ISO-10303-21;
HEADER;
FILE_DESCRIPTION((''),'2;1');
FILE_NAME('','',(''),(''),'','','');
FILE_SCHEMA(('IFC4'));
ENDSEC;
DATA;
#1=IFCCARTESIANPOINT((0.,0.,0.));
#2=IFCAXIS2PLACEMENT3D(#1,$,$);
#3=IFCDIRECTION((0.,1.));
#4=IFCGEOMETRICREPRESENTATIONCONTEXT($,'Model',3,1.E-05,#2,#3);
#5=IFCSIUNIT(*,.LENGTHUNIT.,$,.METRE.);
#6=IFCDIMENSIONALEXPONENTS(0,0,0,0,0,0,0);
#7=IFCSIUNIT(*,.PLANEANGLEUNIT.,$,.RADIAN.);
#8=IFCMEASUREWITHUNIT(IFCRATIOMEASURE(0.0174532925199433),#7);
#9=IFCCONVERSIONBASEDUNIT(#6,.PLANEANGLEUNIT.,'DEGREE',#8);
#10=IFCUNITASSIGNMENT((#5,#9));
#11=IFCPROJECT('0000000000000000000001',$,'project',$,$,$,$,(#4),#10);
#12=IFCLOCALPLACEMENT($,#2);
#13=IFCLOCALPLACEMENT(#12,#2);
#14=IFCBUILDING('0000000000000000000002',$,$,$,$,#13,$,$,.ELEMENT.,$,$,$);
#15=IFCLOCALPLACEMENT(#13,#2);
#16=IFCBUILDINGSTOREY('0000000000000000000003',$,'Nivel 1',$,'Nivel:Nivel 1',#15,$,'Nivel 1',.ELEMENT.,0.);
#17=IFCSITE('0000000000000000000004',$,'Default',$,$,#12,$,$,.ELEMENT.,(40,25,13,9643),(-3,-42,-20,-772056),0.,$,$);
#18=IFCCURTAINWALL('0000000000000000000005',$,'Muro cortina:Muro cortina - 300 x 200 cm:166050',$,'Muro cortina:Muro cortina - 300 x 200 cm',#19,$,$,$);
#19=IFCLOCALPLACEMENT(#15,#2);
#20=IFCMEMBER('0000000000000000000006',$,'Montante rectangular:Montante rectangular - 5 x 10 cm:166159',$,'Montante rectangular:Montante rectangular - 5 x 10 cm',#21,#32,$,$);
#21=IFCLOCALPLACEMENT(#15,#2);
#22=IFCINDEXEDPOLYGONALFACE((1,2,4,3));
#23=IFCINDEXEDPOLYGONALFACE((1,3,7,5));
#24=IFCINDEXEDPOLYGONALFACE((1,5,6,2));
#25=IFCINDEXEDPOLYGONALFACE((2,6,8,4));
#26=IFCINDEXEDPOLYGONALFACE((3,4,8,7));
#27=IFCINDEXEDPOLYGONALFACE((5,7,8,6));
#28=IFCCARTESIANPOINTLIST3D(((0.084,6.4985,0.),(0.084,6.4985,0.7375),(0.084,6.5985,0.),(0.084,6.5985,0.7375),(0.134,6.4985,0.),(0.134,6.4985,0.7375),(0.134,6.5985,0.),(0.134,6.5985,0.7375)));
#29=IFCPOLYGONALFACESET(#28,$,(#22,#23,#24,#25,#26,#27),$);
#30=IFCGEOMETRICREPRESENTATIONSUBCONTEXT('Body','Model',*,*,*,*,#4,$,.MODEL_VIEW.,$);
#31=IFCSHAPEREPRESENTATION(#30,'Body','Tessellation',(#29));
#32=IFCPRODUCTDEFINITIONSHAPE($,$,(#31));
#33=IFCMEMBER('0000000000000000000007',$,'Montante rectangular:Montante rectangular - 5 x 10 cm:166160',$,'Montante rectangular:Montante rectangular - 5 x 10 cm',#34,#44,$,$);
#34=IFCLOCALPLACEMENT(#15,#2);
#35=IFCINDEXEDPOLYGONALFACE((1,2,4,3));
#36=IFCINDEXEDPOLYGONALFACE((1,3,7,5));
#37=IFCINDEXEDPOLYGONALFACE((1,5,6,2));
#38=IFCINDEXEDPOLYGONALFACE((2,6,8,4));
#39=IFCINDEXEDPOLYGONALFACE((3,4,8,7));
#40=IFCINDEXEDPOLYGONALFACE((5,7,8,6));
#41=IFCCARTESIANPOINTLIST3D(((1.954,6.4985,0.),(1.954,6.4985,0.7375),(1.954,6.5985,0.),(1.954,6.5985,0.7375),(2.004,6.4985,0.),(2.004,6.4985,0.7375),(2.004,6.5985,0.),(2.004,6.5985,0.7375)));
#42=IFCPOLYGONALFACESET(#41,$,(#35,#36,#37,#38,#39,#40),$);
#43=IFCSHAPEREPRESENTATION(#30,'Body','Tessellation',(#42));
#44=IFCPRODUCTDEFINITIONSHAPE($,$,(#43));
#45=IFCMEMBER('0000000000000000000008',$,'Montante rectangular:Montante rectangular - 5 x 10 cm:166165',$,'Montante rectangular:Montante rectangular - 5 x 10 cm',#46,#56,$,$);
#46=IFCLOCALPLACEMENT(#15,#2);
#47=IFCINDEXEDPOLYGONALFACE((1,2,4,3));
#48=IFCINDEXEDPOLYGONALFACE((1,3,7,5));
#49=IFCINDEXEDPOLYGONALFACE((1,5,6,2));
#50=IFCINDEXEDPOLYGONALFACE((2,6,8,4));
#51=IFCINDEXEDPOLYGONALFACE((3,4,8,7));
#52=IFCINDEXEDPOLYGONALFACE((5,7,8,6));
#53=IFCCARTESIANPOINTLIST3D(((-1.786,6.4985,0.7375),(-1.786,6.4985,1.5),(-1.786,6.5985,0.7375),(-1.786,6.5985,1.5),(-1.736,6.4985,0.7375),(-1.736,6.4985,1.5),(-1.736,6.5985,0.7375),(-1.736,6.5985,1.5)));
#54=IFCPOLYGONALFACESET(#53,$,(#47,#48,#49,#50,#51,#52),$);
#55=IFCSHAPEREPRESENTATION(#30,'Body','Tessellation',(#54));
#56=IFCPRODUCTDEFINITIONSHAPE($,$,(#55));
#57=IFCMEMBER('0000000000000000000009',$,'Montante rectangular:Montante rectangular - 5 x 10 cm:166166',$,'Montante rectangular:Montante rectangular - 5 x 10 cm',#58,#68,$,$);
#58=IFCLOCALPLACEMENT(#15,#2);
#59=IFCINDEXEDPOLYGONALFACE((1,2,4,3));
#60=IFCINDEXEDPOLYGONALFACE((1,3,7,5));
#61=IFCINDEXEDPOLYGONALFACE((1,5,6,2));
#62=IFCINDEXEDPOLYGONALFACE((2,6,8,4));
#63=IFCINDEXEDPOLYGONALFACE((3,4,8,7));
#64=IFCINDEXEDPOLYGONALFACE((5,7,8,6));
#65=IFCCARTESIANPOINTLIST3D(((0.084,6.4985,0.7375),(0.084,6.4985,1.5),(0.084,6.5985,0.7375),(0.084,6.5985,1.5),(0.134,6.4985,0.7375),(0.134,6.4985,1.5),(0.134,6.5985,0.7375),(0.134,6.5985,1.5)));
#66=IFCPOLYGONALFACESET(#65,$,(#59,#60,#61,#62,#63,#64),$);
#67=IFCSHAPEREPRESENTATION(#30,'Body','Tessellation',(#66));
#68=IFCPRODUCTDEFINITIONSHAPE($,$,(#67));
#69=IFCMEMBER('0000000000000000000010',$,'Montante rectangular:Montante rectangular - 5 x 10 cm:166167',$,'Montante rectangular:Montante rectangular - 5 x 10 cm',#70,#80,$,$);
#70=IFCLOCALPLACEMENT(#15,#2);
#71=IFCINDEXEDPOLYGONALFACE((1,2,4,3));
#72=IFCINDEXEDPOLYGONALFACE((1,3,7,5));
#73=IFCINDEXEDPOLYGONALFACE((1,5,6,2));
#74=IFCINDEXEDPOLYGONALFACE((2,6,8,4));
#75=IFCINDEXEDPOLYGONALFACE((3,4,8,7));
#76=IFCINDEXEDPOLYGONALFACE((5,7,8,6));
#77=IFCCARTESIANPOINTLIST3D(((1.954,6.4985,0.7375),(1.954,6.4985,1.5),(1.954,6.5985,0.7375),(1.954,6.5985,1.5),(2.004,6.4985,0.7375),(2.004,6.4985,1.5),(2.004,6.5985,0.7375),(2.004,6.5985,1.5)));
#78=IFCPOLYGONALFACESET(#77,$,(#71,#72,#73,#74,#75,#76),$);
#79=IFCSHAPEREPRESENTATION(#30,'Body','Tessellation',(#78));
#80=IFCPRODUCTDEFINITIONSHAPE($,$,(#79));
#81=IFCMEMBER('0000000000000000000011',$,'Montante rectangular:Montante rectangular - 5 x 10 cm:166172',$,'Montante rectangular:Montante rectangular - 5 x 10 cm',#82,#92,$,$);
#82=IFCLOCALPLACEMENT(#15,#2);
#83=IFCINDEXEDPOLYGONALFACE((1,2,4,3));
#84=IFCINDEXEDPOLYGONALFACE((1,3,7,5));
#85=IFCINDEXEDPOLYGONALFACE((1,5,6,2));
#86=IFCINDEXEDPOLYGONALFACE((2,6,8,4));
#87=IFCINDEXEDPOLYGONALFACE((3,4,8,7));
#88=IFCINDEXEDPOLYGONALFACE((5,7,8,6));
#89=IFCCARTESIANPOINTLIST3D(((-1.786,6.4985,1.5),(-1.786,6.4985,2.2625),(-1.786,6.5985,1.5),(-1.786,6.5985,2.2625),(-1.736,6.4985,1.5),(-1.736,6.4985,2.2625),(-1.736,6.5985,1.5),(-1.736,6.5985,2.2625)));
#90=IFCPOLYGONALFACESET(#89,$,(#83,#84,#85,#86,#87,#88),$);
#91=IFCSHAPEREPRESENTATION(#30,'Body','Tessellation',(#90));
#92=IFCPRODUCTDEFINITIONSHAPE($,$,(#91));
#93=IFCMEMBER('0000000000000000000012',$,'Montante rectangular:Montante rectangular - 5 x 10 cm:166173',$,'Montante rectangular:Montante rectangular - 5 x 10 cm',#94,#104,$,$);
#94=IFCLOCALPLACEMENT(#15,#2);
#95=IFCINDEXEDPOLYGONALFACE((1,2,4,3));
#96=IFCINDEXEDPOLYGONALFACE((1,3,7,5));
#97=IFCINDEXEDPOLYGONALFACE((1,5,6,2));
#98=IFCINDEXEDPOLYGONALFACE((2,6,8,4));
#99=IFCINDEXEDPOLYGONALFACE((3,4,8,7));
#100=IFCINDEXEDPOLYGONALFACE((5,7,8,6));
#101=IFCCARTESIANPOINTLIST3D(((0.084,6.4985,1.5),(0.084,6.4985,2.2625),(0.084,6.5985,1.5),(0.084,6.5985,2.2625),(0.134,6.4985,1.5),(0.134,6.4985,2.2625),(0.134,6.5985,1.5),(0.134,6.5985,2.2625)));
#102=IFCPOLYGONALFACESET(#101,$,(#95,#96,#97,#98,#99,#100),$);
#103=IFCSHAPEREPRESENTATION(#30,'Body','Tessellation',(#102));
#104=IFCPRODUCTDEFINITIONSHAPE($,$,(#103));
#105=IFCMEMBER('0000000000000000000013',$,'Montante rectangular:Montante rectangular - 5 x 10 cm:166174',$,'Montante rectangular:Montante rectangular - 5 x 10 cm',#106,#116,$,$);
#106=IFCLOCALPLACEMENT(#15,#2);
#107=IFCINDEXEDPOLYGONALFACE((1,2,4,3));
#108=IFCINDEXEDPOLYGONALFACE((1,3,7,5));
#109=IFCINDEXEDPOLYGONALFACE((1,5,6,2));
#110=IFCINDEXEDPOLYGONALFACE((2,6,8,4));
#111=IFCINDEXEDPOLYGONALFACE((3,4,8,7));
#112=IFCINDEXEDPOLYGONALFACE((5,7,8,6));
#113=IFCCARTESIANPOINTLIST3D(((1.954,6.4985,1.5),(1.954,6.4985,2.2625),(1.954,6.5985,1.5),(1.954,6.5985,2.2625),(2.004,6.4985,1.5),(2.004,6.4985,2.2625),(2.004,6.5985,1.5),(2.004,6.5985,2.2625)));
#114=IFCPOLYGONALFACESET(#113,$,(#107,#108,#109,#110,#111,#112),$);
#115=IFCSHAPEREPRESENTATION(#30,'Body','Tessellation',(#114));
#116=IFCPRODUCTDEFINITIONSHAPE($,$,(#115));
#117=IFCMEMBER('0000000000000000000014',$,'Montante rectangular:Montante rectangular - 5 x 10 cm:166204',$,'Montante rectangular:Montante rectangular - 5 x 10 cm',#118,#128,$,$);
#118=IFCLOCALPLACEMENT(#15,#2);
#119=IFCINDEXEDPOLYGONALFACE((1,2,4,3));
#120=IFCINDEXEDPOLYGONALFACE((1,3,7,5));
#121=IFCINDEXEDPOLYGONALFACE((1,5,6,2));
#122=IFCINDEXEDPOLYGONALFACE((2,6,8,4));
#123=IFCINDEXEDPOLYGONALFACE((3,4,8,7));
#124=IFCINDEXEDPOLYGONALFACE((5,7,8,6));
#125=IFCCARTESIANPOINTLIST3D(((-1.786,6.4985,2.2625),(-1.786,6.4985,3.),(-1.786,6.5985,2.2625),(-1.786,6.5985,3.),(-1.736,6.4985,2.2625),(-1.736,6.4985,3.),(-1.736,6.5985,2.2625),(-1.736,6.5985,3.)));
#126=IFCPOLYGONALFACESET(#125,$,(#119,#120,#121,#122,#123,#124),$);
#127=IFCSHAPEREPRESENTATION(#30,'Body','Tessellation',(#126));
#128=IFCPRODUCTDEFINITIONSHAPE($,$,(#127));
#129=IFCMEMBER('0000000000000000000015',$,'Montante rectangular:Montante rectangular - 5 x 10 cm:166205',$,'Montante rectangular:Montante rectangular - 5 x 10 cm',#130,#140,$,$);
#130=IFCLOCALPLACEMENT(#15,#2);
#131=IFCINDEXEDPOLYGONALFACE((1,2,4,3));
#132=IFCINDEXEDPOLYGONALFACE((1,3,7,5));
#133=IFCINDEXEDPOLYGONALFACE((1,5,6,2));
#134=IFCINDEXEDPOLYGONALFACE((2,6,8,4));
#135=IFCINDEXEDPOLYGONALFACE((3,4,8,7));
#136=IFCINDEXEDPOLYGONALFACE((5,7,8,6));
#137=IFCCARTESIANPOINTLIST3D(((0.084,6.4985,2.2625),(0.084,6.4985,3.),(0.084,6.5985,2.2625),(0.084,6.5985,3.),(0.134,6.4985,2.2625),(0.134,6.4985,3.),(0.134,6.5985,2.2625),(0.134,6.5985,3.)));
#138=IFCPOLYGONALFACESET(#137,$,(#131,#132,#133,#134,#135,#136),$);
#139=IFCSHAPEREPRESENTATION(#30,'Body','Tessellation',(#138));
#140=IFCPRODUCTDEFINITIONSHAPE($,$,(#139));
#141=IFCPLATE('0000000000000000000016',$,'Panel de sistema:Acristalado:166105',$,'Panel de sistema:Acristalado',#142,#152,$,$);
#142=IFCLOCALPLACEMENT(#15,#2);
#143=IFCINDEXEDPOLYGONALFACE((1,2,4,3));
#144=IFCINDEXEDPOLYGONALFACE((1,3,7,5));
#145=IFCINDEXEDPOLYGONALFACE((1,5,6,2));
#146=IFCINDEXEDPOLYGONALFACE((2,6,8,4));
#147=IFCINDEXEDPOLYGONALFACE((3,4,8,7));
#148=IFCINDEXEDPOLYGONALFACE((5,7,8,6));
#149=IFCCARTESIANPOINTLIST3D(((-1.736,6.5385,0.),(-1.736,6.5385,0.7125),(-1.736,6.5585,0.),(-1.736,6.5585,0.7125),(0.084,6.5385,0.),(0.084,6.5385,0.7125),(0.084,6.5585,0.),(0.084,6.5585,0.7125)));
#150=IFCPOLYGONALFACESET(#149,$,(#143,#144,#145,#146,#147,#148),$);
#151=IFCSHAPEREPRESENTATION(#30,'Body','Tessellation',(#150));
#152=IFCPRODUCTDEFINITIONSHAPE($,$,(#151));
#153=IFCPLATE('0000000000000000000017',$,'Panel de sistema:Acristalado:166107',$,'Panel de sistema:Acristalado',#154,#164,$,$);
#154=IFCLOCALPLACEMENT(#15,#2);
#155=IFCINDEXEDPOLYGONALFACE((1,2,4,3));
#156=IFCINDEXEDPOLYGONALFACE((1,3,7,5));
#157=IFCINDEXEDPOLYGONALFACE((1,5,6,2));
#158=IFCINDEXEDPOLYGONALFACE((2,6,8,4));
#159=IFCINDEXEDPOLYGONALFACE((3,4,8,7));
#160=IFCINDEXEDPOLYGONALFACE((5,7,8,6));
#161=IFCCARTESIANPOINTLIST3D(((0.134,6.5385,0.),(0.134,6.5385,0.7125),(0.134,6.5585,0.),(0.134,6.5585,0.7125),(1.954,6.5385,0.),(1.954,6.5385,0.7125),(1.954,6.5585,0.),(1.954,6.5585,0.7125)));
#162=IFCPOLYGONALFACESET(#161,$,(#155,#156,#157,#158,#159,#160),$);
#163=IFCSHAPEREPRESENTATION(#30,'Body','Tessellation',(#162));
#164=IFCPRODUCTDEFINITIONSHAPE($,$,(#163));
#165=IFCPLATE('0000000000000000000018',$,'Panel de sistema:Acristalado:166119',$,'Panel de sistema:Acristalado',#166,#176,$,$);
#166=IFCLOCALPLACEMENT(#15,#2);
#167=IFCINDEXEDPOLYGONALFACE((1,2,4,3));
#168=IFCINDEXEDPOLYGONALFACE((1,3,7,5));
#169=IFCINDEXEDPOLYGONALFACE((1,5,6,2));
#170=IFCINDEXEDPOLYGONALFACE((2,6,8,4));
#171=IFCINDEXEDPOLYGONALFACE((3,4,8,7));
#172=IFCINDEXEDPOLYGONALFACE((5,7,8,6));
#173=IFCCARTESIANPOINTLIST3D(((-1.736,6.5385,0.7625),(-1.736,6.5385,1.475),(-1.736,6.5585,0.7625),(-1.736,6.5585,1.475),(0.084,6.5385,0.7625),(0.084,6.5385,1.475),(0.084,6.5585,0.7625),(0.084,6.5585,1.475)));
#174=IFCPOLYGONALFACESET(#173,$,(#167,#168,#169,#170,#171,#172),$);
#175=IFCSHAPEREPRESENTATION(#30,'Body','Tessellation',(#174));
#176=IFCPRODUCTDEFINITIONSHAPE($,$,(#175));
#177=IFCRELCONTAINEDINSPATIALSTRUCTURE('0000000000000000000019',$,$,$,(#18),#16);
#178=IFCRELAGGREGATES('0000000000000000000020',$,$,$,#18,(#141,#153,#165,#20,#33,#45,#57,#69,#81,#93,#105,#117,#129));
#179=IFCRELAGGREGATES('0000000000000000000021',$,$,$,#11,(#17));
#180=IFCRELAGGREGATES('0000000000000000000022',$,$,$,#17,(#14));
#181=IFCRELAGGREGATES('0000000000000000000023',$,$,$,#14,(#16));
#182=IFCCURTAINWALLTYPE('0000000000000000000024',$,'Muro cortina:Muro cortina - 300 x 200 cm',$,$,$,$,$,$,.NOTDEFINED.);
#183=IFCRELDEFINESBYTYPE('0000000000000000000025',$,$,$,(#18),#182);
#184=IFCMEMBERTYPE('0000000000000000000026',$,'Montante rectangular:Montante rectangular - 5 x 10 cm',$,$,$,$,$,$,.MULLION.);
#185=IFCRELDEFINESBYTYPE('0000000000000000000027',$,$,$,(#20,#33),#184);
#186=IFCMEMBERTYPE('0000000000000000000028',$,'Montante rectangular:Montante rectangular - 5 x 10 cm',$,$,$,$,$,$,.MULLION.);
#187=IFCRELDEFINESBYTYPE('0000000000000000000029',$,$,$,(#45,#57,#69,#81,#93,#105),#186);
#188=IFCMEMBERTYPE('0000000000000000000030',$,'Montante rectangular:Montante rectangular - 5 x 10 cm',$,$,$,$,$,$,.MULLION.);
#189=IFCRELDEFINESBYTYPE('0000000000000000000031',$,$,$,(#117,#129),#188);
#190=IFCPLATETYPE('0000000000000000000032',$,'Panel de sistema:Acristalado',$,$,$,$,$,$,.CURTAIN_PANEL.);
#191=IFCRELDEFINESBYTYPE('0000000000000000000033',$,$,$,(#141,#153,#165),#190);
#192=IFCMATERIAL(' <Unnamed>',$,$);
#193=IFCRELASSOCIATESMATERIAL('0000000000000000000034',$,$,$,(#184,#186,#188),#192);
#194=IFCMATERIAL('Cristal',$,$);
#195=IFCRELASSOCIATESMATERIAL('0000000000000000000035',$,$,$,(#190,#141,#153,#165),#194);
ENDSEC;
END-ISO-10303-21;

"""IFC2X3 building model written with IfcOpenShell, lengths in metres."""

from ifc_helpers import new_model, entity, si_unit, converted_unit, direction, frame, origin, origin_2d_with_axis, place, context, subcontext, project, spatial, rectangle, extrude, source, transform, mapped, material, type_object, type_shapes, element, aggregate, save


model = new_model("IFC2X3")

# Units and contexts
model_context = context("Model", 3, precision=1e-05, world=origin(), true_north=direction((0.0, 1.0)))
body_context = subcontext(model_context, "Body", "Model", "MODEL_VIEW")
ifc_project = project(units=[si_unit("LENGTHUNIT", "METRE"), converted_unit("PLANEANGLEUNIT", "DEGREE", entity("IfcRatioMeasure", 0.0174532925199433), si_unit("PLANEANGLEUNIT", "RADIAN"), dimensions=[0, 0, 0, 0, 0, 0, 0])], contexts=[model_context])

# Site, building, storey
site_placement = place(None, origin())
site = spatial("IfcSite", under=ifc_project, at=site_placement, Name="Default", CompositionType="ELEMENT", RefLatitude=(40, 25, 13, 9643), RefLongitude=(-3, -42, -20, -772056), RefElevation=0.0)
building_placement = place(site_placement, origin())
building = spatial("IfcBuilding", under=site, at=building_placement, CompositionType="ELEMENT")
storey_placement = place(building_placement, origin())
storey = spatial("IfcBuildingStorey", under=building, at=storey_placement, Name="Nivel 1", ObjectType="Nivel:Nivel 1", LongName="Nivel 1", CompositionType="ELEMENT", Elevation=0.0)

# Shared definitions
curtain_wall_type = type_object("IfcCurtainWallType", Name="Muro cortina:Muro cortina - 300 x 200 cm", PredefinedType="NOTDEFINED")
ifc_material_1 = material(Name=" <Unnamed>")

# Curtain wall, members, plates
curtain_wall_1_placement = place(storey_placement, origin())
curtain_wall_1 = element("IfcCurtainWall", 1, at=curtain_wall_1_placement, inside=storey, type_object=curtain_wall_type, Name="Muro cortina:Muro cortina - 300 x 200 cm:166050", ObjectType="Muro cortina:Muro cortina - 300 x 200 cm")
member_type_1 = type_object("IfcMemberType", Name="Montante rectangular:Montante rectangular - 5 x 10 cm", PredefinedType="MULLION", material=ifc_material_1)
shared_shape_1 = source(origin(), body_context, "Body", "SweptSolid", [
    extrude(rectangle(XDim=0.1, YDim=0.05, at=origin_2d_with_axis()), frame((0.0, 0.0, -0.7375), z_axis=(0.0, 0.0, 1.0), x_axis=(0.0, -1.0, 0.0)), (0.0, 0.0, 1.0), 0.7375),
])
type_shapes(member_type_1, [shared_shape_1])
member_1_placement = place(storey_placement, frame((0.109, 6.5485, 0.0), z_axis=(0.0, 0.0, -1.0), x_axis=(1.0, 0.0, 0.0)))
member_1 = element("IfcMember", 2, at=member_1_placement, type_object=member_type_1, Name="Montante rectangular:Montante rectangular - 5 x 10 cm:166159", ObjectType="Montante rectangular:Montante rectangular - 5 x 10 cm", context=body_context, shape_type="MappedRepresentation", body=[
    mapped(shared_shape_1, transform((0.0, 0.0, 0.0), scale=1.0)),
])
member_2_placement = place(storey_placement, frame((1.979, 6.5485, 0.0), z_axis=(0.0, 0.0, -1.0), x_axis=(1.0, 0.0, 0.0)))
member_2 = element("IfcMember", 3, at=member_2_placement, type_object=member_type_1, Name="Montante rectangular:Montante rectangular - 5 x 10 cm:166160", ObjectType="Montante rectangular:Montante rectangular - 5 x 10 cm", context=body_context, shape_type="MappedRepresentation", body=[
    mapped(shared_shape_1, transform((0.0, 0.0, 0.0), scale=1.0)),
])
member_type_2 = type_object("IfcMemberType", Name="Montante rectangular:Montante rectangular - 5 x 10 cm", PredefinedType="MULLION", material=ifc_material_1)
shared_shape_2 = source(origin(), body_context, "Body", "SweptSolid", [
    extrude(rectangle(XDim=0.1, YDim=0.05, at=origin_2d_with_axis()), frame((0.0, 0.0, -0.7625), z_axis=(0.0, 0.0, 1.0), x_axis=(0.0, -1.0, 0.0)), (0.0, 0.0, 1.0), 0.7625),
])
type_shapes(member_type_2, [shared_shape_2])
member_3_placement = place(storey_placement, frame((-1.761, 6.5485, 0.7375), z_axis=(0.0, 0.0, -1.0), x_axis=(1.0, 0.0, 0.0)))
member_3 = element("IfcMember", 4, at=member_3_placement, type_object=member_type_2, Name="Montante rectangular:Montante rectangular - 5 x 10 cm:166165", ObjectType="Montante rectangular:Montante rectangular - 5 x 10 cm", context=body_context, shape_type="MappedRepresentation", body=[
    mapped(shared_shape_2, transform((0.0, 0.0, 0.0), scale=1.0)),
])
member_4_placement = place(storey_placement, frame((0.109, 6.5485, 0.7375), z_axis=(0.0, 0.0, -1.0), x_axis=(1.0, 0.0, 0.0)))
member_4 = element("IfcMember", 5, at=member_4_placement, type_object=member_type_2, Name="Montante rectangular:Montante rectangular - 5 x 10 cm:166166", ObjectType="Montante rectangular:Montante rectangular - 5 x 10 cm", context=body_context, shape_type="MappedRepresentation", body=[
    mapped(shared_shape_2, transform((0.0, 0.0, 0.0), scale=1.0)),
])
member_5_placement = place(storey_placement, frame((1.979, 6.5485, 0.7375), z_axis=(0.0, 0.0, -1.0), x_axis=(1.0, 0.0, 0.0)))
member_5 = element("IfcMember", 6, at=member_5_placement, type_object=member_type_2, Name="Montante rectangular:Montante rectangular - 5 x 10 cm:166167", ObjectType="Montante rectangular:Montante rectangular - 5 x 10 cm", context=body_context, shape_type="MappedRepresentation", body=[
    mapped(shared_shape_2, transform((0.0, 0.0, 0.0), scale=1.0)),
])
member_6_placement = place(storey_placement, frame((-1.761, 6.5485, 1.5), z_axis=(0.0, 0.0, -1.0), x_axis=(1.0, 0.0, 0.0)))
member_6 = element("IfcMember", 7, at=member_6_placement, type_object=member_type_2, Name="Montante rectangular:Montante rectangular - 5 x 10 cm:166172", ObjectType="Montante rectangular:Montante rectangular - 5 x 10 cm", context=body_context, shape_type="MappedRepresentation", body=[
    mapped(shared_shape_2, transform((0.0, 0.0, 0.0), scale=1.0)),
])
member_7_placement = place(storey_placement, frame((0.109, 6.5485, 1.5), z_axis=(0.0, 0.0, -1.0), x_axis=(1.0, 0.0, 0.0)))
member_7 = element("IfcMember", 8, at=member_7_placement, type_object=member_type_2, Name="Montante rectangular:Montante rectangular - 5 x 10 cm:166173", ObjectType="Montante rectangular:Montante rectangular - 5 x 10 cm", context=body_context, shape_type="MappedRepresentation", body=[
    mapped(shared_shape_2, transform((0.0, 0.0, 0.0), scale=1.0)),
])
member_8_placement = place(storey_placement, frame((1.979, 6.5485, 1.5), z_axis=(0.0, 0.0, -1.0), x_axis=(1.0, 0.0, 0.0)))
member_8 = element("IfcMember", 9, at=member_8_placement, type_object=member_type_2, Name="Montante rectangular:Montante rectangular - 5 x 10 cm:166174", ObjectType="Montante rectangular:Montante rectangular - 5 x 10 cm", context=body_context, shape_type="MappedRepresentation", body=[
    mapped(shared_shape_2, transform((0.0, 0.0, 0.0), scale=1.0)),
])
member_type_3 = type_object("IfcMemberType", Name="Montante rectangular:Montante rectangular - 5 x 10 cm", PredefinedType="MULLION", material=ifc_material_1)
shared_shape_3 = source(origin(), body_context, "Body", "SweptSolid", [
    extrude(rectangle(XDim=0.1, YDim=0.05, at=origin_2d_with_axis()), frame((0.0, 0.0, -0.7375), z_axis=(0.0, 0.0, 1.0), x_axis=(0.0, -1.0, 0.0)), (0.0, 0.0, 1.0), 0.7375),
])
type_shapes(member_type_3, [shared_shape_3])
member_9_placement = place(storey_placement, frame((-1.761, 6.5485, 2.2625), z_axis=(0.0, 0.0, -1.0), x_axis=(1.0, 0.0, 0.0)))
member_9 = element("IfcMember", 10, at=member_9_placement, type_object=member_type_3, Name="Montante rectangular:Montante rectangular - 5 x 10 cm:166204", ObjectType="Montante rectangular:Montante rectangular - 5 x 10 cm", context=body_context, shape_type="MappedRepresentation", body=[
    mapped(shared_shape_3, transform((0.0, 0.0, 0.0), scale=1.0)),
])
member_10_placement = place(storey_placement, frame((0.109, 6.5485, 2.2625), z_axis=(0.0, 0.0, -1.0), x_axis=(1.0, 0.0, 0.0)))
member_10 = element("IfcMember", 11, at=member_10_placement, type_object=member_type_3, Name="Montante rectangular:Montante rectangular - 5 x 10 cm:166205", ObjectType="Montante rectangular:Montante rectangular - 5 x 10 cm", context=body_context, shape_type="MappedRepresentation", body=[
    mapped(shared_shape_3, transform((0.0, 0.0, 0.0), scale=1.0)),
])
ifc_material_2 = material(Name="Cristal")
plate_type_1 = type_object("IfcPlateType", Name="Panel de sistema:Acristalado", PredefinedType="CURTAIN_PANEL", material=ifc_material_2)
shared_shape_4 = source(origin(), body_context, "Body", "SweptSolid", [
    extrude(rectangle(XDim=0.02, YDim=1.82, at=origin_2d_with_axis()), frame((0.0, 0.0, 0.0), z_axis=(0.0, 0.0, 1.0), x_axis=(0.0, 1.0, 0.0)), (0.0, 0.0, 1.0), 0.7125),
])
type_shapes(plate_type_1, [shared_shape_4])
plate_1_placement = place(curtain_wall_1_placement, frame((-0.826, 6.5485, 0.0)))
plate_1 = element("IfcPlate", 12, at=plate_1_placement, type_object=plate_type_1, material=ifc_material_2, Name="Panel de sistema:Acristalado:166105", ObjectType="Panel de sistema:Acristalado", context=body_context, shape_type="MappedRepresentation", body=[
    mapped(shared_shape_4, transform((0.0, 0.0, 0.0), scale=1.0)),
])
plate_2_placement = place(curtain_wall_1_placement, frame((1.044, 6.5485, 0.0)))
plate_2 = element("IfcPlate", 13, at=plate_2_placement, type_object=plate_type_1, material=ifc_material_2, Name="Panel de sistema:Acristalado:166107", ObjectType="Panel de sistema:Acristalado", context=body_context, shape_type="MappedRepresentation", body=[
    mapped(shared_shape_4, transform((0.0, 0.0, 0.0), scale=1.0)),
])
plate_3_placement = place(curtain_wall_1_placement, frame((-0.826, 6.5485, 0.7625)))
plate_3 = element("IfcPlate", 14, at=plate_3_placement, type_object=plate_type_1, material=ifc_material_2, Name="Panel de sistema:Acristalado:166119", ObjectType="Panel de sistema:Acristalado", context=body_context, shape_type="MappedRepresentation", body=[
    mapped(shared_shape_4, transform((0.0, 0.0, 0.0), scale=1.0)),
])
aggregate(curtain_wall_1, [plate_1, plate_2, plate_3, member_1, member_2, member_3, member_4, member_5, member_6, member_7, member_8, member_9, member_10])

save(model, "model.ifc")
